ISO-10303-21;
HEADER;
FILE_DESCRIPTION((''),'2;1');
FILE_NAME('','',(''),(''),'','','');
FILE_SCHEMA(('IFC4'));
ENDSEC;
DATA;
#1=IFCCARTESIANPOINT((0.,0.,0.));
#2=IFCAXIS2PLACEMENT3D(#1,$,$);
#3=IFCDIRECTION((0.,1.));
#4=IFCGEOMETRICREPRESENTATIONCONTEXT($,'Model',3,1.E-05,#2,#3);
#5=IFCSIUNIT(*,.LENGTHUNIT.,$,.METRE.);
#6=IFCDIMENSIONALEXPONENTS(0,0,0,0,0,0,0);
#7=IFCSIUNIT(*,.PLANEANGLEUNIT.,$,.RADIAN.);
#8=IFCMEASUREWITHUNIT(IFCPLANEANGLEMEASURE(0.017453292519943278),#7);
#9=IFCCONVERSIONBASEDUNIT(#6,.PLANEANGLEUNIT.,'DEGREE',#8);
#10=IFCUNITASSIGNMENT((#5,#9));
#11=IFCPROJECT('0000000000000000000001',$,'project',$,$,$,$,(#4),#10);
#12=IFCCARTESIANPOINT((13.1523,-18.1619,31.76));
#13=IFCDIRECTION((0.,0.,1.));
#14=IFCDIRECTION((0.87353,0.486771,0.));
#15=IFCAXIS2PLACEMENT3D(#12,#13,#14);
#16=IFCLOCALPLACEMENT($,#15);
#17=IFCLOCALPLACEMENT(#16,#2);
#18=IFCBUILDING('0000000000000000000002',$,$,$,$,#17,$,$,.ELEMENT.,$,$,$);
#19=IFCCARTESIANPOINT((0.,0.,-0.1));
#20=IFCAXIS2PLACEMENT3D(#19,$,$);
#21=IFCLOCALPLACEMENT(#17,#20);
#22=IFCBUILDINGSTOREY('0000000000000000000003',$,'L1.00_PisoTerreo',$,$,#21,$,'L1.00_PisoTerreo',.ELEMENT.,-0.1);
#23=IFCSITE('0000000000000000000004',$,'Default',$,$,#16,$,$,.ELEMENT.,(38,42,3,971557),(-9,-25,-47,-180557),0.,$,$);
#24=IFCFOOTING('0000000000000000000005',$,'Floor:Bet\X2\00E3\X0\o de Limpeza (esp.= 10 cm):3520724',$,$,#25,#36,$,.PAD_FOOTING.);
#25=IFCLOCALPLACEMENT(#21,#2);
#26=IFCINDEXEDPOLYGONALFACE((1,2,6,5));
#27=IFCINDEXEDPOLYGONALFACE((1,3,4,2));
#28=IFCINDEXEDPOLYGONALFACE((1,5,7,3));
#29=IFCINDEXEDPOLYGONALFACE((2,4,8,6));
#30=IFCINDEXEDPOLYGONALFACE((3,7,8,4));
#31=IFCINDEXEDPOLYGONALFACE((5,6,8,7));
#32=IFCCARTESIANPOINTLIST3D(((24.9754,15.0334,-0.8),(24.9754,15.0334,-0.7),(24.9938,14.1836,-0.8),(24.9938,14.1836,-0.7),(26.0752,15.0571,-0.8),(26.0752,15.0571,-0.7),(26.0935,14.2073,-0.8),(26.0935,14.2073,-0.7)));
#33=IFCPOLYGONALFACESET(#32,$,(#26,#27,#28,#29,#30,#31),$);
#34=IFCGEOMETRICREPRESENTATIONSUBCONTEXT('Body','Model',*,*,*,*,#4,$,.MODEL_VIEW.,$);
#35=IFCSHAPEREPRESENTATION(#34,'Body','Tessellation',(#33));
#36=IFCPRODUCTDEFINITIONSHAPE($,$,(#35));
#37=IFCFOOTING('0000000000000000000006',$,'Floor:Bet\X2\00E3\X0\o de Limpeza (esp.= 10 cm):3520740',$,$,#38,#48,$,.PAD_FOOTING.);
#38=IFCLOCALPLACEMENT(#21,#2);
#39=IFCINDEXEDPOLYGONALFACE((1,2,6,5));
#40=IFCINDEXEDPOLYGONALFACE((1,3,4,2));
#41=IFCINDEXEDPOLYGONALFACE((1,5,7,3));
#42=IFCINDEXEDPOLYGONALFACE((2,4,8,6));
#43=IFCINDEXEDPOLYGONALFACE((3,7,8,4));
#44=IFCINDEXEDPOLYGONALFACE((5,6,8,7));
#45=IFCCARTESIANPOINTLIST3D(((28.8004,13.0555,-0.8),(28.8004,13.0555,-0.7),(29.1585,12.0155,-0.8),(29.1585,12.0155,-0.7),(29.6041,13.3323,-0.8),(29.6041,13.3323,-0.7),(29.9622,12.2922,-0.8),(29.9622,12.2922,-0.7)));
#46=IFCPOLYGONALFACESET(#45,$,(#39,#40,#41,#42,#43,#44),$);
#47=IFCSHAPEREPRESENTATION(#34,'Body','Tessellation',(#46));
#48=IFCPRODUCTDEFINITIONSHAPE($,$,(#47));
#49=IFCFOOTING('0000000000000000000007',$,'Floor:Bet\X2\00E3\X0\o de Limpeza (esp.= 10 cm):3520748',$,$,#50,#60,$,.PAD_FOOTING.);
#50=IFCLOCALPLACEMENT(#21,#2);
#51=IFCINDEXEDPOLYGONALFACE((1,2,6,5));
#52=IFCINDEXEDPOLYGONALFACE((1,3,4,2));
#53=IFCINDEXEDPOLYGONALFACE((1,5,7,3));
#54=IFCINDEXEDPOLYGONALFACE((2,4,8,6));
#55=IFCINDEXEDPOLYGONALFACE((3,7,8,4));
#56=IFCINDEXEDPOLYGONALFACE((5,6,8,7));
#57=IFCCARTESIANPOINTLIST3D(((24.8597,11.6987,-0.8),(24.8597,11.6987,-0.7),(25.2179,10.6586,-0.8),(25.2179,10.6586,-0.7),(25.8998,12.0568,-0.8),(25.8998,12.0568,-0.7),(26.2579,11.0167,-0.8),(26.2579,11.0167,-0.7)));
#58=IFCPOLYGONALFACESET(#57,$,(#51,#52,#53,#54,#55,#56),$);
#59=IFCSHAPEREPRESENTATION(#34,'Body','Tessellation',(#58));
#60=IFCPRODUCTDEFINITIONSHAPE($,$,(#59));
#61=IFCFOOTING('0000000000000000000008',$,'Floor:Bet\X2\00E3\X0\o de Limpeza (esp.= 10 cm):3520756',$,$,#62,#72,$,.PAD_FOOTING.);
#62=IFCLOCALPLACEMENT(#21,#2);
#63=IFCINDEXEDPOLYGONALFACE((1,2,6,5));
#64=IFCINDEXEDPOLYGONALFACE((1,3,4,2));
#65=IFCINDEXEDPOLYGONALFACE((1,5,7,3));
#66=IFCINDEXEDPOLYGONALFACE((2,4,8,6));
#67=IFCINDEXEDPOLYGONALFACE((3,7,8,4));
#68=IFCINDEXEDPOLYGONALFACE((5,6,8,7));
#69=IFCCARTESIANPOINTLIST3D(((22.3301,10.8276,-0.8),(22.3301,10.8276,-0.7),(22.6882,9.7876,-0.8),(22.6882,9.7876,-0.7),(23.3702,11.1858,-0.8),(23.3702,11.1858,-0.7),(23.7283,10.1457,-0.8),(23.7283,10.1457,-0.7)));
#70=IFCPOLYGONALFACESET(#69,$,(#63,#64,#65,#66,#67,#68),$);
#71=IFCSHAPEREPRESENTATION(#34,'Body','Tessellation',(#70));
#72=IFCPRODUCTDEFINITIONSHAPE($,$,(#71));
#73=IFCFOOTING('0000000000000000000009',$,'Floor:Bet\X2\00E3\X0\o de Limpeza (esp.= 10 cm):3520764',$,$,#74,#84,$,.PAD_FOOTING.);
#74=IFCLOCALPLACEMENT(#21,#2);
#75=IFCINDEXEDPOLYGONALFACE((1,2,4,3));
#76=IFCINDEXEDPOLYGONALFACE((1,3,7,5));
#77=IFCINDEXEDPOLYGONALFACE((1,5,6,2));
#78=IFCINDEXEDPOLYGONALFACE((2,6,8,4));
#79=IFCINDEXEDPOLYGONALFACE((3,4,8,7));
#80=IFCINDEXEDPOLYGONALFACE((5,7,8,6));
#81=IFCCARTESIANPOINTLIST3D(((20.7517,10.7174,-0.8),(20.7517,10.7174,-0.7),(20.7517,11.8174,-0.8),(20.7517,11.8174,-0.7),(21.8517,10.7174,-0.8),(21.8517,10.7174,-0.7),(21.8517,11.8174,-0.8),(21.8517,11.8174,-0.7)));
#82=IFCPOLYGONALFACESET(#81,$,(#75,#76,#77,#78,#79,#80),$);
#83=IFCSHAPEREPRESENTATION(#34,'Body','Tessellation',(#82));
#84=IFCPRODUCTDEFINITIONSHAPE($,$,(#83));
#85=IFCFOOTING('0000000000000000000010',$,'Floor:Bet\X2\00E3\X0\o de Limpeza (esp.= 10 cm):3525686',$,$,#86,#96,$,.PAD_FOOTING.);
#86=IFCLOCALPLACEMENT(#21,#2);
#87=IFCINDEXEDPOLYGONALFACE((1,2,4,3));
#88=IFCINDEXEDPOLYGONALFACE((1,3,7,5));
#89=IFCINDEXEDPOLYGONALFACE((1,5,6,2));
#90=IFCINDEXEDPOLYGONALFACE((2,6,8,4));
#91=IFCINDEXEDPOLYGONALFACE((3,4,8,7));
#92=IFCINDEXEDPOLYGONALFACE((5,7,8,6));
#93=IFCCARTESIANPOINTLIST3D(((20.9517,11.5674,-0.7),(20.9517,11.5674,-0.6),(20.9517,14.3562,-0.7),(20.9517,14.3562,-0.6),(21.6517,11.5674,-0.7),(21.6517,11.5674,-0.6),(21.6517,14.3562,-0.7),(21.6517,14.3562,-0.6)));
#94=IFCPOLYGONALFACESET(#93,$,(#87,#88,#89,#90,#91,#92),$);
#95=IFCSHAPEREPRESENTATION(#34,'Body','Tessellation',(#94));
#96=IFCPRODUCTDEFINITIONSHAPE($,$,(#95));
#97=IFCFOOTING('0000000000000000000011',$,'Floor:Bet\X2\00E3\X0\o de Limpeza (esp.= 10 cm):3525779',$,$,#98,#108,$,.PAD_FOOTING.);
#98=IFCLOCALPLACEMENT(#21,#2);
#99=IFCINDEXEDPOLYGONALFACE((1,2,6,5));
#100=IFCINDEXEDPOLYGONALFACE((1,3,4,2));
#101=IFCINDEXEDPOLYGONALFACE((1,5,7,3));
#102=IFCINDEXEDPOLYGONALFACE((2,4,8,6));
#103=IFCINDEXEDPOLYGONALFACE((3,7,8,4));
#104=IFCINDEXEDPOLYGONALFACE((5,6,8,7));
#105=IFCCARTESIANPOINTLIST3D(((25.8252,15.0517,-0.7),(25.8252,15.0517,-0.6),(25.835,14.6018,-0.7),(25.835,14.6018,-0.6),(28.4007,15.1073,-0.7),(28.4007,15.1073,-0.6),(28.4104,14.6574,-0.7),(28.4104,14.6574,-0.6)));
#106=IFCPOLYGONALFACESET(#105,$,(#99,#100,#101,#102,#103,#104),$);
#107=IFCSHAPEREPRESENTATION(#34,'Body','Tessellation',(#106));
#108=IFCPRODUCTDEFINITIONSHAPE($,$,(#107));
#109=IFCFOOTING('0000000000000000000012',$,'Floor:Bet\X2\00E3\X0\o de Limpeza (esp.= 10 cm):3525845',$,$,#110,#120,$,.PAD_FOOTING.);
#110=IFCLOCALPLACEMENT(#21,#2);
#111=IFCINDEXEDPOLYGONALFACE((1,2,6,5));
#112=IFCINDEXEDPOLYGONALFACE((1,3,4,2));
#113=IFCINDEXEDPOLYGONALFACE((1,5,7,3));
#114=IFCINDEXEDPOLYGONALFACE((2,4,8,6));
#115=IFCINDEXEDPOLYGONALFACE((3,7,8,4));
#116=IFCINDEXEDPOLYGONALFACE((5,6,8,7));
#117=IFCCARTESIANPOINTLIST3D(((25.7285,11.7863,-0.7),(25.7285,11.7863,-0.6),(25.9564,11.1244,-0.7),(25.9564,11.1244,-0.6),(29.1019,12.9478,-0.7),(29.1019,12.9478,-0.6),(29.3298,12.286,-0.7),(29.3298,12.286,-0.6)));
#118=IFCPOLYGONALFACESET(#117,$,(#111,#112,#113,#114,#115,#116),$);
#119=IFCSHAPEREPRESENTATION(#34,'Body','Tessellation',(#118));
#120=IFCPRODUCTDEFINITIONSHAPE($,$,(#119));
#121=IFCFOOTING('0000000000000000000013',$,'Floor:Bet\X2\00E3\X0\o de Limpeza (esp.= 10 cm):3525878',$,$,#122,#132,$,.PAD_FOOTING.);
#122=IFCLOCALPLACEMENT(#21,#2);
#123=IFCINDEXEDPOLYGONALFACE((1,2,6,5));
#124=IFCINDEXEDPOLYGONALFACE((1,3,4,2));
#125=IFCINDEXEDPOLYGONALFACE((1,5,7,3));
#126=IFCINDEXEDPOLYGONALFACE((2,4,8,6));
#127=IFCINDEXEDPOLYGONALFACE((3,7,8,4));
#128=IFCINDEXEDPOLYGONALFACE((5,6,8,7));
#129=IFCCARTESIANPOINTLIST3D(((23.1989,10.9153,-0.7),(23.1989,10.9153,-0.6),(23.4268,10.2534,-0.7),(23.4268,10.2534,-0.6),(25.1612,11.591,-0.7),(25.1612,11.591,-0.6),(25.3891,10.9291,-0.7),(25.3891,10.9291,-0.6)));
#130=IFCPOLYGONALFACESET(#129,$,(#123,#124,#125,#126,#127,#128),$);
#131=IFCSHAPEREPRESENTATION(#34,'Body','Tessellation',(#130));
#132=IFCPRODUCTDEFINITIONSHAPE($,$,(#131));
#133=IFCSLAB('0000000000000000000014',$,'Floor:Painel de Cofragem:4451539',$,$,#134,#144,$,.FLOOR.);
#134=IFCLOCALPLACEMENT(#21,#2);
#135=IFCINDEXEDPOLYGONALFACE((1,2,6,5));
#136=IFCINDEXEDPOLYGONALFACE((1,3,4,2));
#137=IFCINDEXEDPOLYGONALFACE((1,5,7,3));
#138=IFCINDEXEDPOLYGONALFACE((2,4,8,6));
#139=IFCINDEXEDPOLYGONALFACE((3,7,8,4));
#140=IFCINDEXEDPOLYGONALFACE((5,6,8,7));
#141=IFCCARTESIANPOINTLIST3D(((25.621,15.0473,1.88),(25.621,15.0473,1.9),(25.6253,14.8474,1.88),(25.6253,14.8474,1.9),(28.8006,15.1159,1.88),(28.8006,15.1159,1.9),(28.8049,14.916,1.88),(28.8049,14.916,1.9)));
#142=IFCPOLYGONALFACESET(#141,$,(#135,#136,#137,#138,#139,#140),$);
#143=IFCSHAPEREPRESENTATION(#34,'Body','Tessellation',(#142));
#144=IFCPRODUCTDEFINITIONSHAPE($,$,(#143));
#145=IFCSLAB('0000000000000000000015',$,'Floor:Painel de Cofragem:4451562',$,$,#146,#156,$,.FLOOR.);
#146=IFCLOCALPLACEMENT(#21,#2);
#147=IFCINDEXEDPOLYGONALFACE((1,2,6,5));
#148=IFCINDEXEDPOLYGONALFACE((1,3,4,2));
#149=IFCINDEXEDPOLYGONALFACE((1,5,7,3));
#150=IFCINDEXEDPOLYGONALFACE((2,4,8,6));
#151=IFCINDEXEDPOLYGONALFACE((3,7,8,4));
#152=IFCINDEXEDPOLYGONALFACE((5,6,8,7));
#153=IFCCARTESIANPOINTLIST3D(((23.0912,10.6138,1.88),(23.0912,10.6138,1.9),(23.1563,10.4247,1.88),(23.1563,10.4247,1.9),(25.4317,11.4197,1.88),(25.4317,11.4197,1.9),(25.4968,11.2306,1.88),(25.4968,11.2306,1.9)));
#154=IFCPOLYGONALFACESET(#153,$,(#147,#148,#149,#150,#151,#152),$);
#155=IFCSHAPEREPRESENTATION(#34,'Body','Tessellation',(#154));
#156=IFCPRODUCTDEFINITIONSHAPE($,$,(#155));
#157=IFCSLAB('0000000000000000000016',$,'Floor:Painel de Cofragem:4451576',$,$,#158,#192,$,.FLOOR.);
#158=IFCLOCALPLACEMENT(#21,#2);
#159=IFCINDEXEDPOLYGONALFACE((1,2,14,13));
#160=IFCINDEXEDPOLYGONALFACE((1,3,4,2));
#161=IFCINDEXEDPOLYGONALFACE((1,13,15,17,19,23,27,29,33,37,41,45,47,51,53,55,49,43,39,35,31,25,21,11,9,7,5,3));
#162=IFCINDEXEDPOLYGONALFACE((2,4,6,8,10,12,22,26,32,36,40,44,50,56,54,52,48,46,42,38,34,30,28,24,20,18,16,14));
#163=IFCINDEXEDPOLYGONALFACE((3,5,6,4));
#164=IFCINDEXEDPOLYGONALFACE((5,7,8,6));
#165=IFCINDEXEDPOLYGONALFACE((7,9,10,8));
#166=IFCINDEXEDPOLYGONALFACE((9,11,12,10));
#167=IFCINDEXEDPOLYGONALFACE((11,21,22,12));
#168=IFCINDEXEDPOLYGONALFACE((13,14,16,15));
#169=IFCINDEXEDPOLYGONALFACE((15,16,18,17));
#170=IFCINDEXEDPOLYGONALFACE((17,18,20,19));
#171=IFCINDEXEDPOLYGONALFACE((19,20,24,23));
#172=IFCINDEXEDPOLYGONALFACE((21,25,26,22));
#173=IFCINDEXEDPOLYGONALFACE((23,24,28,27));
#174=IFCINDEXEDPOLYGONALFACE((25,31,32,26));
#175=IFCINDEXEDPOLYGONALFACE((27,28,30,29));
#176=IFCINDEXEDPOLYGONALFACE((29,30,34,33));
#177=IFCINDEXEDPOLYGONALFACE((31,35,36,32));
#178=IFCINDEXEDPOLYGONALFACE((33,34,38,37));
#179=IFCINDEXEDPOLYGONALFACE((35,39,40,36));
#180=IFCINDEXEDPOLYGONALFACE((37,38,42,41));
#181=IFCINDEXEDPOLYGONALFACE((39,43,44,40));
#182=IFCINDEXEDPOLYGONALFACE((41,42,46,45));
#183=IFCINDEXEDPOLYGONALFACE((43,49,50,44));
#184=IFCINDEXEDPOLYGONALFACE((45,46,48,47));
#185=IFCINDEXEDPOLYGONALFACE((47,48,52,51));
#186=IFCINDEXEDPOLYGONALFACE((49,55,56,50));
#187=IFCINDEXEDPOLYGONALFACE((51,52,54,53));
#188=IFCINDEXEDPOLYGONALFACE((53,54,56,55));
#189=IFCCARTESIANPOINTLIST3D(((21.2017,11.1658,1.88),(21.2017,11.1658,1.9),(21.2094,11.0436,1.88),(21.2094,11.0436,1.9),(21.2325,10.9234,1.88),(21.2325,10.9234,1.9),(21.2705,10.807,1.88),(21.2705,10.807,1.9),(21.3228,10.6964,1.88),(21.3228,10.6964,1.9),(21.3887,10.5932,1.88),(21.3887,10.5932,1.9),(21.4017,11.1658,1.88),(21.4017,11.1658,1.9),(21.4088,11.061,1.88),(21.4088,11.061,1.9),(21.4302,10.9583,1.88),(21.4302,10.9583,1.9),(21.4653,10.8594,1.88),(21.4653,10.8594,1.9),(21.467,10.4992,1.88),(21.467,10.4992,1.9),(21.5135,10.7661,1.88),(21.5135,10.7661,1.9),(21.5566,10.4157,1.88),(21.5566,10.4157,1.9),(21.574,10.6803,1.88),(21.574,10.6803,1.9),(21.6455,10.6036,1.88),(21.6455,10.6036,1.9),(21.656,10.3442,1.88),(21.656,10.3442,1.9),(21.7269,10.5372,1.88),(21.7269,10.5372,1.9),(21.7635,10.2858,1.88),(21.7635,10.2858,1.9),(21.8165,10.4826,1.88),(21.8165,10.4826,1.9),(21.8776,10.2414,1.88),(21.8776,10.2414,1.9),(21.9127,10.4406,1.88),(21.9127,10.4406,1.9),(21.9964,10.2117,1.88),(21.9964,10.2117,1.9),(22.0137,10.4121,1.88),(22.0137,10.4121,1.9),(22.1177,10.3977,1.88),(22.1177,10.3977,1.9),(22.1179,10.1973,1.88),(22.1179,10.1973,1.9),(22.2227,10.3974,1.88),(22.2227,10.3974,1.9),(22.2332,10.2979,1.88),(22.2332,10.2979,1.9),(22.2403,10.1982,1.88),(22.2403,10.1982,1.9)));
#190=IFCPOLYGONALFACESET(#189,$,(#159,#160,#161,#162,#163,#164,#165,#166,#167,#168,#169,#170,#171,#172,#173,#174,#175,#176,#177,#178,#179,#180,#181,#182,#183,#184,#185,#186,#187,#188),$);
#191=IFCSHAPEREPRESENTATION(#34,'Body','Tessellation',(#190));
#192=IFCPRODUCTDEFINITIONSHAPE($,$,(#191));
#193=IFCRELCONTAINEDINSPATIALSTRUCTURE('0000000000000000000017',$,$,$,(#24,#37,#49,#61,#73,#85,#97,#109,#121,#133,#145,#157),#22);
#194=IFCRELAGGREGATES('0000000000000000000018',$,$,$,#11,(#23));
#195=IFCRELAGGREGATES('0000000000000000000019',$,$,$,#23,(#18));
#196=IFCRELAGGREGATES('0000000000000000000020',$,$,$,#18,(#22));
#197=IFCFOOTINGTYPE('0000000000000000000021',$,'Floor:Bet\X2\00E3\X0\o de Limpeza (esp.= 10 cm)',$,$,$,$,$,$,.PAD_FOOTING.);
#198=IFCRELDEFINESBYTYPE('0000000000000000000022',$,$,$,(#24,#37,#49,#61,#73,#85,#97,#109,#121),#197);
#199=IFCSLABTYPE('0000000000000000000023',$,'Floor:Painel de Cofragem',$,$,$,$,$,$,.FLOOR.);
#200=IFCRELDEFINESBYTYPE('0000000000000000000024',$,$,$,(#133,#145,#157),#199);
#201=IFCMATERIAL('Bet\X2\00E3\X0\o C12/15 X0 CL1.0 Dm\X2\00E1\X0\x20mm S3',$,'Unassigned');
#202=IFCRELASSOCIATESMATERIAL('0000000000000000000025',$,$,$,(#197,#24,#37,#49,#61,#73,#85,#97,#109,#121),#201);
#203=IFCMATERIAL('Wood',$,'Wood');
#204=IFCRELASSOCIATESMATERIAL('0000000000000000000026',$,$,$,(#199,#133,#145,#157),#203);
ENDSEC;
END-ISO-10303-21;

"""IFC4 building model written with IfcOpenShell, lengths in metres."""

from ifc_helpers import new_model, entity, si_unit, converted_unit, direction, frame, origin, place, context, subcontext, project, spatial, line, arc, indexed_curve, outline, extrude, material, type_object, element, save


model = new_model("IFC4")

# Units and contexts
model_context = context("Model", 3, precision=1e-05, world=origin(), true_north=direction((0.0, 1.0)))
body_context = subcontext(model_context, "Body", "Model", "MODEL_VIEW")
ifc_project = project(units=[si_unit("LENGTHUNIT", "METRE"), converted_unit("PLANEANGLEUNIT", "DEGREE", entity("IfcPlaneAngleMeasure", 0.017453292519943278), si_unit("PLANEANGLEUNIT", "RADIAN"), dimensions=[0, 0, 0, 0, 0, 0, 0])], contexts=[model_context])

# Site, building, storey
site_placement = place(None, frame((13.1523, -18.1619, 31.76), z_axis=(0.0, 0.0, 1.0), x_axis=(0.87353, 0.486771, 0.0)))
site = spatial("IfcSite", under=ifc_project, at=site_placement, Name="Default", CompositionType="ELEMENT", RefLatitude=(38, 42, 3, 971557), RefLongitude=(-9, -25, -47, -180557), RefElevation=0.0)
building_placement = place(site_placement, origin())
building = spatial("IfcBuilding", under=site, at=building_placement, CompositionType="ELEMENT")
storey_placement = place(building_placement, frame((0.0, 0.0, -0.1)))
storey = spatial("IfcBuildingStorey", under=building, at=storey_placement, Name="L1.00_PisoTerreo", LongName="L1.00_PisoTerreo", CompositionType="ELEMENT", Elevation=-0.1)

# Footings
ifc_material_1 = material(Name="Betão C12/15 X0 CL1.0 Dmáx20mm S3", Category="Unassigned")
footing_type = type_object("IfcFootingType", Name="Floor:Betão de Limpeza (esp.= 10 cm)", PredefinedType="PAD_FOOTING", material=ifc_material_1)
footing_1_placement = place(storey_placement, origin())
element("IfcFooting", 1, at=footing_1_placement, inside=storey, type_object=footing_type, material=ifc_material_1, Name="Floor:Betão de Limpeza (esp.= 10 cm):3520724", PredefinedType="PAD_FOOTING", context=body_context, shape_type="SweptSolid", body=[
    extrude(outline(indexed_curve([(-0.425, -0.55), (0.425, -0.55), (0.425, 0.55), (-0.425, 0.55), (-0.425, -0.55)], self_intersect=False)), frame((25.5345, 14.6203, -0.7), z_axis=(0.0, 0.0, -1.0), x_axis=(0.021581, -0.999767, 0.0)), (0.0, 0.0, 1.0), 0.1),
])
footing_2_placement = place(storey_placement, origin())
element("IfcFooting", 2, at=footing_2_placement, inside=storey, type_object=footing_type, material=ifc_material_1, Name="Floor:Betão de Limpeza (esp.= 10 cm):3520740", PredefinedType="PAD_FOOTING", context=body_context, shape_type="SweptSolid", body=[
    extrude(outline(indexed_curve([(-0.55, -0.425), (0.55, -0.425), (0.55, 0.425), (-0.55, 0.425), (-0.55, -0.425)], self_intersect=False)), frame((29.3813, 12.6739, -0.7), z_axis=(0.0, 0.0, -1.0), x_axis=(0.325568, -0.945519, 0.0)), (0.0, 0.0, 1.0), 0.1),
])
footing_3_placement = place(storey_placement, origin())
element("IfcFooting", 3, at=footing_3_placement, inside=storey, type_object=footing_type, material=ifc_material_1, Name="Floor:Betão de Limpeza (esp.= 10 cm):3520748", PredefinedType="PAD_FOOTING", context=body_context, shape_type="SweptSolid", body=[
    extrude(outline(indexed_curve([(-0.55, -0.55), (0.55, -0.55), (0.55, 0.55), (-0.55, 0.55), (-0.55, -0.55)], self_intersect=False)), frame((25.5588, 11.3577, -0.7), z_axis=(0.0, 0.0, -1.0), x_axis=(0.325568, -0.945519, 0.0)), (0.0, 0.0, 1.0), 0.1),
])
footing_4_placement = place(storey_placement, origin())
element("IfcFooting", 4, at=footing_4_placement, inside=storey, type_object=footing_type, material=ifc_material_1, Name="Floor:Betão de Limpeza (esp.= 10 cm):3520756", PredefinedType="PAD_FOOTING", context=body_context, shape_type="SweptSolid", body=[
    extrude(outline(indexed_curve([(-0.55, -0.55), (0.55, -0.55), (0.55, 0.55), (-0.55, 0.55), (-0.55, -0.55)], self_intersect=False)), frame((23.0292, 10.4867, -0.7), z_axis=(0.0, 0.0, -1.0), x_axis=(0.325568, -0.945519, 0.0)), (0.0, 0.0, 1.0), 0.1),
])
footing_5_placement = place(storey_placement, origin())
element("IfcFooting", 5, at=footing_5_placement, inside=storey, type_object=footing_type, material=ifc_material_1, Name="Floor:Betão de Limpeza (esp.= 10 cm):3520764", PredefinedType="PAD_FOOTING", context=body_context, shape_type="SweptSolid", body=[
    extrude(outline(indexed_curve([(-0.55, -0.55), (0.55, -0.55), (0.55, 0.55), (-0.55, 0.55), (-0.55, -0.55)], self_intersect=False)), frame((21.3017, 11.2674, -0.7), z_axis=(0.0, 0.0, -1.0), x_axis=(0.0, 1.0, 0.0)), (0.0, 0.0, 1.0), 0.1),
])
footing_6_placement = place(storey_placement, origin())
element("IfcFooting", 6, at=footing_6_placement, inside=storey, type_object=footing_type, material=ifc_material_1, Name="Floor:Betão de Limpeza (esp.= 10 cm):3525686", PredefinedType="PAD_FOOTING", context=body_context, shape_type="SweptSolid", body=[
    extrude(outline(indexed_curve([(-1.3944, -0.35), (1.3944, -0.35), (1.3944, 0.35), (-1.3944, 0.35), (-1.3944, -0.35)], self_intersect=False)), frame((21.3017, 12.9618, -0.6), z_axis=(0.0, 0.0, -1.0), x_axis=(0.0, 1.0, 0.0)), (0.0, 0.0, 1.0), 0.1),
])
footing_7_placement = place(storey_placement, origin())
element("IfcFooting", 7, at=footing_7_placement, inside=storey, type_object=footing_type, material=ifc_material_1, Name="Floor:Betão de Limpeza (esp.= 10 cm):3525779", PredefinedType="PAD_FOOTING", context=body_context, shape_type="SweptSolid", body=[
    extrude(outline(indexed_curve([(-1.288, -0.225), (1.288, -0.225), (1.288, 0.225), (-1.288, 0.225), (-1.288, -0.225)], self_intersect=False)), frame((27.1178, 14.8546, -0.6), z_axis=(0.0, 0.0, -1.0), x_axis=(0.999767, 0.021581, 0.0)), (0.0, 0.0, 1.0), 0.1),
])
footing_8_placement = place(storey_placement, origin())
element("IfcFooting", 8, at=footing_8_placement, inside=storey, type_object=footing_type, material=ifc_material_1, Name="Floor:Betão de Limpeza (esp.= 10 cm):3525845", PredefinedType="PAD_FOOTING", context=body_context, shape_type="SweptSolid", body=[
    extrude(outline(indexed_curve([(-1.7838, -0.35), (1.7838, -0.35), (1.7838, 0.35), (-1.7838, 0.35), (-1.7838, -0.35)], self_intersect=False)), frame((27.5292, 12.0361, -0.6), z_axis=(0.0, 0.0, -1.0), x_axis=(0.945519, 0.325568, 0.0)), (0.0, 0.0, 1.0), 0.1),
])
footing_9_placement = place(storey_placement, origin())
element("IfcFooting", 9, at=footing_9_placement, inside=storey, type_object=footing_type, material=ifc_material_1, Name="Floor:Betão de Limpeza (esp.= 10 cm):3525878", PredefinedType="PAD_FOOTING", context=body_context, shape_type="SweptSolid", body=[
    extrude(outline(indexed_curve([(-0.35, -1.0377), (0.35, -1.0377), (0.35, 1.0377), (-0.35, 1.0377), (-0.35, -1.0377)], self_intersect=False)), frame((24.294, 10.9222, -0.6), z_axis=(0.0, 0.0, -1.0), x_axis=(0.325568, -0.945519, 0.0)), (0.0, 0.0, 1.0), 0.1),
])

# Slabs
ifc_material_2 = material(Name="Wood", Category="Wood")
slab_type = type_object("IfcSlabType", Name="Floor:Painel de Cofragem", PredefinedType="FLOOR", material=ifc_material_2)
slab_1_placement = place(storey_placement, origin())
element("IfcSlab", 10, at=slab_1_placement, inside=storey, type_object=slab_type, material=ifc_material_2, Name="Floor:Painel de Cofragem:4451539", PredefinedType="FLOOR", context=body_context, shape_type="SweptSolid", body=[
    extrude(outline(indexed_curve([(-0.1, -1.5902), (0.1, -1.5902), (0.1, 1.5902), (-0.1, 1.5902), (-0.1, -1.5902)], self_intersect=False)), frame((27.2129, 14.9816, 1.9), z_axis=(0.0, 0.0, -1.0), x_axis=(0.021581, -0.999767, 0.0)), (0.0, 0.0, 1.0), 0.02),
])
slab_2_placement = place(storey_placement, origin())
element("IfcSlab", 11, at=slab_2_placement, inside=storey, type_object=slab_type, material=ifc_material_2, Name="Floor:Painel de Cofragem:4451562", PredefinedType="FLOOR", context=body_context, shape_type="SweptSolid", body=[
    extrude(outline(indexed_curve([(-1.2377, -0.1), (1.2377, -0.1), (1.2377, 0.1), (-1.2377, 0.1), (-1.2377, -0.1)], self_intersect=False)), frame((24.294, 10.9222, 1.9), z_axis=(0.0, 0.0, -1.0), x_axis=(0.945519, 0.325568, 0.0)), (0.0, 0.0, 1.0), 0.02),
])
slab_3_placement = place(storey_placement, origin())
element("IfcSlab", 12, at=slab_3_placement, inside=storey, type_object=slab_type, material=ifc_material_2, Name="Floor:Painel de Cofragem:4451576", PredefinedType="FLOOR", context=body_context, shape_type="SweptSolid", body=[
    extrude(outline(indexed_curve([(-0.6582, -0.5207), (-0.4582, -0.5207), (-0.2144, 0.0415), (0.3627, 0.2476), (0.3733, 0.3471), (0.3804, 0.4468), (-0.3494, 0.189)], segments=[line(1, 2), arc(2, 3, 4), line(4, 5, 6), arc(6, 7, 1)], self_intersect=False)), frame((21.8599, 10.645, 1.9), z_axis=(0.0, 0.0, -1.0), x_axis=(1.0, 0.0, 0.0)), (0.0, 0.0, 1.0), 0.02),
])

save(model, "model.ifc")
